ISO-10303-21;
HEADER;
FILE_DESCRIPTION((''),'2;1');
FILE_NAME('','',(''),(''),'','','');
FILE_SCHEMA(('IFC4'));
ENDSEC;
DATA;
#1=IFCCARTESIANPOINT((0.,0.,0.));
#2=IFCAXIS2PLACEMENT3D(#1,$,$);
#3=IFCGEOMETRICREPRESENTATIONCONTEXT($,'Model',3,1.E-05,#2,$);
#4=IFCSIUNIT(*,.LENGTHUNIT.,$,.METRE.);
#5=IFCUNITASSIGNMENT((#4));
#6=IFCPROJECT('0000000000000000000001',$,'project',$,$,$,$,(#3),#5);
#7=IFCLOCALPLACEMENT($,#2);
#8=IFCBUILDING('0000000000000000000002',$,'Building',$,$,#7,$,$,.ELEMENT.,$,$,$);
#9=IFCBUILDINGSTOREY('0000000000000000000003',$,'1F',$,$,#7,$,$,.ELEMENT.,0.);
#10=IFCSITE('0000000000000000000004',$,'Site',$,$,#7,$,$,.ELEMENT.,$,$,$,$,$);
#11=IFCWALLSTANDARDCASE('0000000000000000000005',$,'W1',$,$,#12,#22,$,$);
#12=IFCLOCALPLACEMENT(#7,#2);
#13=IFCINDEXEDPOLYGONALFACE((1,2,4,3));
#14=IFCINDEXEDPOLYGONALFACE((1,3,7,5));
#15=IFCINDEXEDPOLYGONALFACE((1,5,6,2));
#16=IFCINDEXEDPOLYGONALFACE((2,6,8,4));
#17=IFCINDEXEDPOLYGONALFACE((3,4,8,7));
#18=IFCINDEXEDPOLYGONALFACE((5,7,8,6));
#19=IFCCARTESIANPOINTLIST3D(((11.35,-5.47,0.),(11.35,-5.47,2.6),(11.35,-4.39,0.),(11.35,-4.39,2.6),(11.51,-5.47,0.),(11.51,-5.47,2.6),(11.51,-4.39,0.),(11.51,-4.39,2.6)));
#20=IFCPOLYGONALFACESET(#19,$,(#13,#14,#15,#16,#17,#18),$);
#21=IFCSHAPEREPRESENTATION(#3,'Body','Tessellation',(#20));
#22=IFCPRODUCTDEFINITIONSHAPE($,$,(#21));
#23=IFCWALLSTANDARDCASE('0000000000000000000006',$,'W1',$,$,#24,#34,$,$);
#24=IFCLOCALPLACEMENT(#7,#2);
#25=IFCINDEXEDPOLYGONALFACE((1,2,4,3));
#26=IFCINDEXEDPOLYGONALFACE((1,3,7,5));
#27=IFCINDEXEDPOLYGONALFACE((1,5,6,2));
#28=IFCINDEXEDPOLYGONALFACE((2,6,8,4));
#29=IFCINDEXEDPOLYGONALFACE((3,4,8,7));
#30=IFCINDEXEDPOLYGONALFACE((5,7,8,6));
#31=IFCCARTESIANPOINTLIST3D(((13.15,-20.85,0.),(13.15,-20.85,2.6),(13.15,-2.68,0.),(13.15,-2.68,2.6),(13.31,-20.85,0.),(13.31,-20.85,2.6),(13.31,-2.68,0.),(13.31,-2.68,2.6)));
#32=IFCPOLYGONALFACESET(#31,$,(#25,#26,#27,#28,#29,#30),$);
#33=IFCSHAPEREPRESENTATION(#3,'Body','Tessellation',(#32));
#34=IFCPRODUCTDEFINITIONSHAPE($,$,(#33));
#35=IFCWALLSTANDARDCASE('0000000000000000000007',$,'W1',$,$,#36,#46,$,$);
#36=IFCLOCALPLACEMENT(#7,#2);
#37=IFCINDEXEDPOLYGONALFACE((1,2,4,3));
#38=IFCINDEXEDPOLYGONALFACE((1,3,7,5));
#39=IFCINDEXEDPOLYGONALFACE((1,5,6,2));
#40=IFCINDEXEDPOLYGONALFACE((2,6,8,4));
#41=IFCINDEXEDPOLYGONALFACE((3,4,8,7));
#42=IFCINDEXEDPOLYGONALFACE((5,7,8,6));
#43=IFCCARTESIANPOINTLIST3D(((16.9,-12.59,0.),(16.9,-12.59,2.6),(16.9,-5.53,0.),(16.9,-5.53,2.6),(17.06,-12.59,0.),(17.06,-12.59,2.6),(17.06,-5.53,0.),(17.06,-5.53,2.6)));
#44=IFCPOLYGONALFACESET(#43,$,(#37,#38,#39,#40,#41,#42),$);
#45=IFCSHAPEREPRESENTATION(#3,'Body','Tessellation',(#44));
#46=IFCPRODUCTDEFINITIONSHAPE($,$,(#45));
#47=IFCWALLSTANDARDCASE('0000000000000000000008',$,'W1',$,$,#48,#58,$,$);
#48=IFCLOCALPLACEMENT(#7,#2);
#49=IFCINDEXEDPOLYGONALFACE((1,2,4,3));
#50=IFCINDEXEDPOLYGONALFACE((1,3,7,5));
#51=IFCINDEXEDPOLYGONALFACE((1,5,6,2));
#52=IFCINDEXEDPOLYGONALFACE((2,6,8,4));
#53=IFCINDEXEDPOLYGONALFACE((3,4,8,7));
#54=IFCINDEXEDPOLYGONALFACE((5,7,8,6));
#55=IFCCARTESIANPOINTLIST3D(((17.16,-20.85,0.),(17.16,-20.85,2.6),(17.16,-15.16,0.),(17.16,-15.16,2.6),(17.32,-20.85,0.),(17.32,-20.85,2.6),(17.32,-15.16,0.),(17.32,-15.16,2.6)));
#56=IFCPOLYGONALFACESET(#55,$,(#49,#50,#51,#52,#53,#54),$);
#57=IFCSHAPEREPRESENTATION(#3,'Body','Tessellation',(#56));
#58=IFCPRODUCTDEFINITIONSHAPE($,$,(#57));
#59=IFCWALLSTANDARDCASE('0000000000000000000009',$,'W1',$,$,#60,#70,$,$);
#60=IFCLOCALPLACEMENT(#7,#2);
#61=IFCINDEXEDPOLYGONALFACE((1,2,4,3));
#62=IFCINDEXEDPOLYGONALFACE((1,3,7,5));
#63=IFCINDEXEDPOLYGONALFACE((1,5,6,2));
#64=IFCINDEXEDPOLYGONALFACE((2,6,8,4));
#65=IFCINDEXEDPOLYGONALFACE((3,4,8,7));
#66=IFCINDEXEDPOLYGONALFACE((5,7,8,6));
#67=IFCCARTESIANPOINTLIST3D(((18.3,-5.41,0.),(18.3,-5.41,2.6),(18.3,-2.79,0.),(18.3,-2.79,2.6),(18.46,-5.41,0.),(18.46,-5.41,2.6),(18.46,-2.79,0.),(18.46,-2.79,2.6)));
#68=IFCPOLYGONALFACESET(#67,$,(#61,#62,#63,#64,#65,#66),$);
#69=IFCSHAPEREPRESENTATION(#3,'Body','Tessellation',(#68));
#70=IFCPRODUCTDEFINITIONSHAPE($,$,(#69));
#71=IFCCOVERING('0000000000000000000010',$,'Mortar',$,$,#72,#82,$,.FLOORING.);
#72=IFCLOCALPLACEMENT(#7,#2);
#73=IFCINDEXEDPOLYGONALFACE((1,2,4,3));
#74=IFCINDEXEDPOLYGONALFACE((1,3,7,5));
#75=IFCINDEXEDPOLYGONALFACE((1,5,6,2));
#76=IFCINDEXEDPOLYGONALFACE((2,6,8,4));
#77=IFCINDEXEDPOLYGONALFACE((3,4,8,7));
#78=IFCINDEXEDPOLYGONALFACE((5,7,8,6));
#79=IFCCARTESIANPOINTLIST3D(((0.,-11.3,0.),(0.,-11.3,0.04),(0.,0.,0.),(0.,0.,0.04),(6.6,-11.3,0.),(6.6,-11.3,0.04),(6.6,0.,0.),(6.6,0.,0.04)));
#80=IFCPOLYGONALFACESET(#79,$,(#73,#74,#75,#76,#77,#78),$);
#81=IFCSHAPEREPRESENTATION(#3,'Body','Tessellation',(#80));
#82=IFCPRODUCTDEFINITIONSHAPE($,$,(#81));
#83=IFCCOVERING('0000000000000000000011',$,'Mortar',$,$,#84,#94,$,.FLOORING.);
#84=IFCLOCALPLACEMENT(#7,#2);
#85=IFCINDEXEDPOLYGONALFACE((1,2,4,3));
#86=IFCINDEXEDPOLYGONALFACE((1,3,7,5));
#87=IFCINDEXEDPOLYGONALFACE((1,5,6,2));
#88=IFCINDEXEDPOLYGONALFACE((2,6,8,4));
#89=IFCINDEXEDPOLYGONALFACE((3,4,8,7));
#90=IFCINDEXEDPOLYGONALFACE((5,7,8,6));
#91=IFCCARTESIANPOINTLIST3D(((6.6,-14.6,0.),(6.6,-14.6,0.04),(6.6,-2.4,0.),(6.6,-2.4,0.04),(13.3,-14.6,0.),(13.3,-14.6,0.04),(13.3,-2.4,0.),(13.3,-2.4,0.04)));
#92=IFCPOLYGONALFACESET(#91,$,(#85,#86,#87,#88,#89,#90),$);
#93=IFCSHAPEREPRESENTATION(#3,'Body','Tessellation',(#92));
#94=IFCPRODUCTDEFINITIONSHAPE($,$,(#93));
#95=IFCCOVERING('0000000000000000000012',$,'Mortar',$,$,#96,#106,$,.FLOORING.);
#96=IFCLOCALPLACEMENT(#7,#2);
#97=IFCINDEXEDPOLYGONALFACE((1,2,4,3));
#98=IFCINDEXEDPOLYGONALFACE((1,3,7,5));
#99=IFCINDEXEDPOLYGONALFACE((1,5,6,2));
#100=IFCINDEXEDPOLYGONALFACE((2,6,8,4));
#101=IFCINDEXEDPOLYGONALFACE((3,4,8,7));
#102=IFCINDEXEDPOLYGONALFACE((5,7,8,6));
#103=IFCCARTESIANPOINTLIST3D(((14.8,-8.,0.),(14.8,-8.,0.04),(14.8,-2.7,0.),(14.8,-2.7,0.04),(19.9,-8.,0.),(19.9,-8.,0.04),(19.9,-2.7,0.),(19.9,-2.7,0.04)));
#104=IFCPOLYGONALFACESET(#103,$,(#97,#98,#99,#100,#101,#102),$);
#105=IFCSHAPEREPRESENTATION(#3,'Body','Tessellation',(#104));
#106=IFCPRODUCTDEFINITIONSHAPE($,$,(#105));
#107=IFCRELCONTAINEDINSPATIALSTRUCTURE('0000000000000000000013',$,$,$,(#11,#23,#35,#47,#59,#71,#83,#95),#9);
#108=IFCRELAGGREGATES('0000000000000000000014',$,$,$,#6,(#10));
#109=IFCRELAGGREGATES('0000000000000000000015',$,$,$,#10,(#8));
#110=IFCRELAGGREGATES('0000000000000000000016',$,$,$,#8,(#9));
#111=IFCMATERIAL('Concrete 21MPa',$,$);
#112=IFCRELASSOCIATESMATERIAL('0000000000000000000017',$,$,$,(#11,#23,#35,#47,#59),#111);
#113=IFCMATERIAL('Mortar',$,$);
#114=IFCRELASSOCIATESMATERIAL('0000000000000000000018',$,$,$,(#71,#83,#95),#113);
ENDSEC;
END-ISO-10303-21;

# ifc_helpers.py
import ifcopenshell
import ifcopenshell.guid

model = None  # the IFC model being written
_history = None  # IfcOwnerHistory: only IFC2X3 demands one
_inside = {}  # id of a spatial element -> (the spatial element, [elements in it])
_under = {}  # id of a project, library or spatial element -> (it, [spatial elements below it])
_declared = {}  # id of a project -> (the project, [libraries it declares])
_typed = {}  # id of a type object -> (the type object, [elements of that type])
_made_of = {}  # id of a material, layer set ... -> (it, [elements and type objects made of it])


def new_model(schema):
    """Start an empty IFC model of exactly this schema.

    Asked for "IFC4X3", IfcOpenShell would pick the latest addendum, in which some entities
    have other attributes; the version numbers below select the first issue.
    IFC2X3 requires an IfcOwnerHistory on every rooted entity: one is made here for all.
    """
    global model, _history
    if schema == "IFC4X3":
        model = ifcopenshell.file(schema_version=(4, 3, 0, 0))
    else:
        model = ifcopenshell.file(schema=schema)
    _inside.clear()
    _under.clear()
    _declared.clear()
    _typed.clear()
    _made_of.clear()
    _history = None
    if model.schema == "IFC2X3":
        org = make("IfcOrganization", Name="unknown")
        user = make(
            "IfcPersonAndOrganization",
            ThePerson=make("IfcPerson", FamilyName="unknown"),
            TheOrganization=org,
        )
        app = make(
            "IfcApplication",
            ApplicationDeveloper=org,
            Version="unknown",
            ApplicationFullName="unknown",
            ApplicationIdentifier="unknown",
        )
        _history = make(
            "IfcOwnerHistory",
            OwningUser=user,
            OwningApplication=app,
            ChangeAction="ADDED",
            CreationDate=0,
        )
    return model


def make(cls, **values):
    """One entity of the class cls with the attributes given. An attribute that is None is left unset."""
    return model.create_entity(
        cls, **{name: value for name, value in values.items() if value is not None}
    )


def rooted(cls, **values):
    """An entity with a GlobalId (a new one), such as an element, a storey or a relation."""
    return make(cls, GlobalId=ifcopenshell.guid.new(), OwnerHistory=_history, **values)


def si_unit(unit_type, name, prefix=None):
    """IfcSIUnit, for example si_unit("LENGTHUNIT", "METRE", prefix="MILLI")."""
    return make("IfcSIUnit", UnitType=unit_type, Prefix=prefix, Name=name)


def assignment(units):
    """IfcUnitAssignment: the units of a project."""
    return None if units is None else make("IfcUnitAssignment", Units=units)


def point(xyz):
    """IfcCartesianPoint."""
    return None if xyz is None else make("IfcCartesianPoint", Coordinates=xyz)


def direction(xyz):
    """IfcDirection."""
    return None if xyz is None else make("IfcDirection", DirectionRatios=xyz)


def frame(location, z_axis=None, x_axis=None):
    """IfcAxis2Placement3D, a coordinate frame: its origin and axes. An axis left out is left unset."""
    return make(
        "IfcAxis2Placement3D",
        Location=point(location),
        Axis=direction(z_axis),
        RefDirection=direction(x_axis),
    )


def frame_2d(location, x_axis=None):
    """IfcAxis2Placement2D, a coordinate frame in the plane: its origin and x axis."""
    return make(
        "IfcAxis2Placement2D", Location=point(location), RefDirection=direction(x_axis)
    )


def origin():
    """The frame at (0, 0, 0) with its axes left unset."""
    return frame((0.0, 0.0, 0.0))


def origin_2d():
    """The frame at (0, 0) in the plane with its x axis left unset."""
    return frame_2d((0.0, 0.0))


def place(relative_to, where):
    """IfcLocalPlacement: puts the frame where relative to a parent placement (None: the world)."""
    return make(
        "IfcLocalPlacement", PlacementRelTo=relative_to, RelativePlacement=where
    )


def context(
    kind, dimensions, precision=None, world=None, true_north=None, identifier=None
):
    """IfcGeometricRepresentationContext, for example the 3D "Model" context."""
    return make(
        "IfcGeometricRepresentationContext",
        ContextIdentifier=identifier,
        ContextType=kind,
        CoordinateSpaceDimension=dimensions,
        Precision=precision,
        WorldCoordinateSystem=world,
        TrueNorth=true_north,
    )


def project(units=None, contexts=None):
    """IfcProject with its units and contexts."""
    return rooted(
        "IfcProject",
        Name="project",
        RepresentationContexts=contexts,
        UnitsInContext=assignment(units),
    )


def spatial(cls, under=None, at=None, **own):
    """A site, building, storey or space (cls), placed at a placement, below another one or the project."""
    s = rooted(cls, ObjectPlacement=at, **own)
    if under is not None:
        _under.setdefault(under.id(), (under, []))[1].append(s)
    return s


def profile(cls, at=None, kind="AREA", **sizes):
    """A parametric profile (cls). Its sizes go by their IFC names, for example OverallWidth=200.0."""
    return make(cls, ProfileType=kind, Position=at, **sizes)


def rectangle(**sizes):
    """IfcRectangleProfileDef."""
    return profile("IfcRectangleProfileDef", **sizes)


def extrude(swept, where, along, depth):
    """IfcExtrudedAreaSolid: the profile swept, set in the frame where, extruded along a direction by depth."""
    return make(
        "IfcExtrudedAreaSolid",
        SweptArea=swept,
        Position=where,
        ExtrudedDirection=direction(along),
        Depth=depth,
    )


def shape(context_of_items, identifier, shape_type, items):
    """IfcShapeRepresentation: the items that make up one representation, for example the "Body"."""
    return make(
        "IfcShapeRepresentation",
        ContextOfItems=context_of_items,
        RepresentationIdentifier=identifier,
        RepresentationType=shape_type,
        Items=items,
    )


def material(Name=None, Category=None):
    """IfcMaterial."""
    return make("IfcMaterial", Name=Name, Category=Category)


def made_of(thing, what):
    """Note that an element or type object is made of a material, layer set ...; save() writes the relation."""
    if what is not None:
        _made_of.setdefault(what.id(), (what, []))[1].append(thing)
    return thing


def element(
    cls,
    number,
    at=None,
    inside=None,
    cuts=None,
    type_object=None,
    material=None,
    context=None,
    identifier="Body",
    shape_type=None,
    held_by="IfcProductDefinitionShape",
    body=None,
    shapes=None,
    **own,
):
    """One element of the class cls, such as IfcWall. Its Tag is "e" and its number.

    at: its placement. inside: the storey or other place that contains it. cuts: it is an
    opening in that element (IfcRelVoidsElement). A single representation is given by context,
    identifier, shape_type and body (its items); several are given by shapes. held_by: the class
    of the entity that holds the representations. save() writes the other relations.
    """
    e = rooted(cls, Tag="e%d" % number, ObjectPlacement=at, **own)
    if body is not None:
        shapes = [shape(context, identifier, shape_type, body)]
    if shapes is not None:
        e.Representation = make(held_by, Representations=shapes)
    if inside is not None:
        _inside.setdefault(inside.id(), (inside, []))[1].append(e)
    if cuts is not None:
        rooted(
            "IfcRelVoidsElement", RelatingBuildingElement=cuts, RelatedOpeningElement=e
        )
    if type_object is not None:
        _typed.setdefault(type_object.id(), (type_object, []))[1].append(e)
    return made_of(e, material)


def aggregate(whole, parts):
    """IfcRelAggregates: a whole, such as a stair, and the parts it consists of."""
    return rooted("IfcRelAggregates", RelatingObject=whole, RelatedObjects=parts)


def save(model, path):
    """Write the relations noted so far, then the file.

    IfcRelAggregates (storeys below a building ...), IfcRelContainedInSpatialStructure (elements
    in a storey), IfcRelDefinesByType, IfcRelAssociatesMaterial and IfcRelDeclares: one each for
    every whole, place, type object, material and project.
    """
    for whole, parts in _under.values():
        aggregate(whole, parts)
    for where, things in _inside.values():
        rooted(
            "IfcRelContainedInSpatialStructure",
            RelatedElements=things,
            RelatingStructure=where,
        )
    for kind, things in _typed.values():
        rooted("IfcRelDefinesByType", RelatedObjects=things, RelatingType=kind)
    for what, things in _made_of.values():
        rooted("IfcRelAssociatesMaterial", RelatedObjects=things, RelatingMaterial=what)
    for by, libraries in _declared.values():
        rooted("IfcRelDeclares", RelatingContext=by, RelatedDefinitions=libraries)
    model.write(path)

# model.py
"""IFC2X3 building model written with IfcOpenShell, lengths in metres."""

from ifc_helpers import new_model, si_unit, frame, origin, origin_2d, place, context, project, spatial, rectangle, extrude, material, element, save


model = new_model("IFC2X3")

# Units and contexts
model_context = context("Model", 3, precision=1e-05, world=origin())
ifc_project = project(units=[si_unit("LENGTHUNIT", "METRE")], contexts=[model_context])

# Site, building, storey
placement = place(None, origin())
site = spatial("IfcSite", under=ifc_project, at=placement, Name="Site", CompositionType="ELEMENT")
building = spatial("IfcBuilding", under=site, at=placement, Name="Building", CompositionType="ELEMENT")
storey = spatial("IfcBuildingStorey", under=building, at=placement, Name="1F", CompositionType="ELEMENT", Elevation=0.0)

# Shared definitions
ifc_material_1 = material(Name="Concrete 21MPa")

# Walls
wall_1_placement = place(None, frame((11.43, -4.93, 0.0)))
element("IfcWallStandardCase", 1, at=wall_1_placement, inside=storey, material=ifc_material_1, Name="W1", context=model_context, shape_type="SweptSolid", body=[
    extrude(rectangle(XDim=0.16, YDim=1.08, at=origin_2d()), origin(), (0.0, 0.0, 1.0), 2.6),
])
wall_2_placement = place(None, frame((13.23, -11.765, 0.0)))
element("IfcWallStandardCase", 2, at=wall_2_placement, inside=storey, material=ifc_material_1, Name="W1", context=model_context, shape_type="SweptSolid", body=[
    extrude(rectangle(XDim=0.16, YDim=18.17, at=origin_2d()), origin(), (0.0, 0.0, 1.0), 2.6),
])
wall_3_placement = place(None, frame((16.98, -9.06, 0.0)))
element("IfcWallStandardCase", 3, at=wall_3_placement, inside=storey, material=ifc_material_1, Name="W1", context=model_context, shape_type="SweptSolid", body=[
    extrude(rectangle(XDim=0.16, YDim=7.06, at=origin_2d()), origin(), (0.0, 0.0, 1.0), 2.6),
])
wall_4_placement = place(None, frame((17.24, -18.005, 0.0)))
element("IfcWallStandardCase", 4, at=wall_4_placement, inside=storey, material=ifc_material_1, Name="W1", context=model_context, shape_type="SweptSolid", body=[
    extrude(rectangle(XDim=0.16, YDim=5.69, at=origin_2d()), origin(), (0.0, 0.0, 1.0), 2.6),
])
wall_5_placement = place(None, frame((18.38, -4.1, 0.0)))
element("IfcWallStandardCase", 5, at=wall_5_placement, inside=storey, material=ifc_material_1, Name="W1", context=model_context, shape_type="SweptSolid", body=[
    extrude(rectangle(XDim=0.16, YDim=2.62, at=origin_2d()), origin(), (0.0, 0.0, 1.0), 2.6),
])

# Coverings
ifc_material_2 = material(Name="Mortar")
covering_1_placement = place(None, frame((3.3, -5.65, 0.0)))
element("IfcCovering", 6, at=covering_1_placement, inside=storey, material=ifc_material_2, Name="Mortar", PredefinedType="FLOORING", context=model_context, shape_type="SweptSolid", body=[
    extrude(rectangle(XDim=6.6, YDim=11.3, at=origin_2d()), origin(), (0.0, 0.0, 1.0), 0.04),
])
covering_2_placement = place(None, frame((9.95, -8.5, 0.0)))
element("IfcCovering", 7, at=covering_2_placement, inside=storey, material=ifc_material_2, Name="Mortar", PredefinedType="FLOORING", context=model_context, shape_type="SweptSolid", body=[
    extrude(rectangle(XDim=6.7, YDim=12.2, at=origin_2d()), origin(), (0.0, 0.0, 1.0), 0.04),
])
covering_3_placement = place(None, frame((17.35, -5.35, 0.0)))
element("IfcCovering", 8, at=covering_3_placement, inside=storey, material=ifc_material_2, Name="Mortar", PredefinedType="FLOORING", context=model_context, shape_type="SweptSolid", body=[
    extrude(rectangle(XDim=5.1, YDim=5.3, at=origin_2d()), origin(), (0.0, 0.0, 1.0), 0.04),
])

save(model, "model.ifc")
